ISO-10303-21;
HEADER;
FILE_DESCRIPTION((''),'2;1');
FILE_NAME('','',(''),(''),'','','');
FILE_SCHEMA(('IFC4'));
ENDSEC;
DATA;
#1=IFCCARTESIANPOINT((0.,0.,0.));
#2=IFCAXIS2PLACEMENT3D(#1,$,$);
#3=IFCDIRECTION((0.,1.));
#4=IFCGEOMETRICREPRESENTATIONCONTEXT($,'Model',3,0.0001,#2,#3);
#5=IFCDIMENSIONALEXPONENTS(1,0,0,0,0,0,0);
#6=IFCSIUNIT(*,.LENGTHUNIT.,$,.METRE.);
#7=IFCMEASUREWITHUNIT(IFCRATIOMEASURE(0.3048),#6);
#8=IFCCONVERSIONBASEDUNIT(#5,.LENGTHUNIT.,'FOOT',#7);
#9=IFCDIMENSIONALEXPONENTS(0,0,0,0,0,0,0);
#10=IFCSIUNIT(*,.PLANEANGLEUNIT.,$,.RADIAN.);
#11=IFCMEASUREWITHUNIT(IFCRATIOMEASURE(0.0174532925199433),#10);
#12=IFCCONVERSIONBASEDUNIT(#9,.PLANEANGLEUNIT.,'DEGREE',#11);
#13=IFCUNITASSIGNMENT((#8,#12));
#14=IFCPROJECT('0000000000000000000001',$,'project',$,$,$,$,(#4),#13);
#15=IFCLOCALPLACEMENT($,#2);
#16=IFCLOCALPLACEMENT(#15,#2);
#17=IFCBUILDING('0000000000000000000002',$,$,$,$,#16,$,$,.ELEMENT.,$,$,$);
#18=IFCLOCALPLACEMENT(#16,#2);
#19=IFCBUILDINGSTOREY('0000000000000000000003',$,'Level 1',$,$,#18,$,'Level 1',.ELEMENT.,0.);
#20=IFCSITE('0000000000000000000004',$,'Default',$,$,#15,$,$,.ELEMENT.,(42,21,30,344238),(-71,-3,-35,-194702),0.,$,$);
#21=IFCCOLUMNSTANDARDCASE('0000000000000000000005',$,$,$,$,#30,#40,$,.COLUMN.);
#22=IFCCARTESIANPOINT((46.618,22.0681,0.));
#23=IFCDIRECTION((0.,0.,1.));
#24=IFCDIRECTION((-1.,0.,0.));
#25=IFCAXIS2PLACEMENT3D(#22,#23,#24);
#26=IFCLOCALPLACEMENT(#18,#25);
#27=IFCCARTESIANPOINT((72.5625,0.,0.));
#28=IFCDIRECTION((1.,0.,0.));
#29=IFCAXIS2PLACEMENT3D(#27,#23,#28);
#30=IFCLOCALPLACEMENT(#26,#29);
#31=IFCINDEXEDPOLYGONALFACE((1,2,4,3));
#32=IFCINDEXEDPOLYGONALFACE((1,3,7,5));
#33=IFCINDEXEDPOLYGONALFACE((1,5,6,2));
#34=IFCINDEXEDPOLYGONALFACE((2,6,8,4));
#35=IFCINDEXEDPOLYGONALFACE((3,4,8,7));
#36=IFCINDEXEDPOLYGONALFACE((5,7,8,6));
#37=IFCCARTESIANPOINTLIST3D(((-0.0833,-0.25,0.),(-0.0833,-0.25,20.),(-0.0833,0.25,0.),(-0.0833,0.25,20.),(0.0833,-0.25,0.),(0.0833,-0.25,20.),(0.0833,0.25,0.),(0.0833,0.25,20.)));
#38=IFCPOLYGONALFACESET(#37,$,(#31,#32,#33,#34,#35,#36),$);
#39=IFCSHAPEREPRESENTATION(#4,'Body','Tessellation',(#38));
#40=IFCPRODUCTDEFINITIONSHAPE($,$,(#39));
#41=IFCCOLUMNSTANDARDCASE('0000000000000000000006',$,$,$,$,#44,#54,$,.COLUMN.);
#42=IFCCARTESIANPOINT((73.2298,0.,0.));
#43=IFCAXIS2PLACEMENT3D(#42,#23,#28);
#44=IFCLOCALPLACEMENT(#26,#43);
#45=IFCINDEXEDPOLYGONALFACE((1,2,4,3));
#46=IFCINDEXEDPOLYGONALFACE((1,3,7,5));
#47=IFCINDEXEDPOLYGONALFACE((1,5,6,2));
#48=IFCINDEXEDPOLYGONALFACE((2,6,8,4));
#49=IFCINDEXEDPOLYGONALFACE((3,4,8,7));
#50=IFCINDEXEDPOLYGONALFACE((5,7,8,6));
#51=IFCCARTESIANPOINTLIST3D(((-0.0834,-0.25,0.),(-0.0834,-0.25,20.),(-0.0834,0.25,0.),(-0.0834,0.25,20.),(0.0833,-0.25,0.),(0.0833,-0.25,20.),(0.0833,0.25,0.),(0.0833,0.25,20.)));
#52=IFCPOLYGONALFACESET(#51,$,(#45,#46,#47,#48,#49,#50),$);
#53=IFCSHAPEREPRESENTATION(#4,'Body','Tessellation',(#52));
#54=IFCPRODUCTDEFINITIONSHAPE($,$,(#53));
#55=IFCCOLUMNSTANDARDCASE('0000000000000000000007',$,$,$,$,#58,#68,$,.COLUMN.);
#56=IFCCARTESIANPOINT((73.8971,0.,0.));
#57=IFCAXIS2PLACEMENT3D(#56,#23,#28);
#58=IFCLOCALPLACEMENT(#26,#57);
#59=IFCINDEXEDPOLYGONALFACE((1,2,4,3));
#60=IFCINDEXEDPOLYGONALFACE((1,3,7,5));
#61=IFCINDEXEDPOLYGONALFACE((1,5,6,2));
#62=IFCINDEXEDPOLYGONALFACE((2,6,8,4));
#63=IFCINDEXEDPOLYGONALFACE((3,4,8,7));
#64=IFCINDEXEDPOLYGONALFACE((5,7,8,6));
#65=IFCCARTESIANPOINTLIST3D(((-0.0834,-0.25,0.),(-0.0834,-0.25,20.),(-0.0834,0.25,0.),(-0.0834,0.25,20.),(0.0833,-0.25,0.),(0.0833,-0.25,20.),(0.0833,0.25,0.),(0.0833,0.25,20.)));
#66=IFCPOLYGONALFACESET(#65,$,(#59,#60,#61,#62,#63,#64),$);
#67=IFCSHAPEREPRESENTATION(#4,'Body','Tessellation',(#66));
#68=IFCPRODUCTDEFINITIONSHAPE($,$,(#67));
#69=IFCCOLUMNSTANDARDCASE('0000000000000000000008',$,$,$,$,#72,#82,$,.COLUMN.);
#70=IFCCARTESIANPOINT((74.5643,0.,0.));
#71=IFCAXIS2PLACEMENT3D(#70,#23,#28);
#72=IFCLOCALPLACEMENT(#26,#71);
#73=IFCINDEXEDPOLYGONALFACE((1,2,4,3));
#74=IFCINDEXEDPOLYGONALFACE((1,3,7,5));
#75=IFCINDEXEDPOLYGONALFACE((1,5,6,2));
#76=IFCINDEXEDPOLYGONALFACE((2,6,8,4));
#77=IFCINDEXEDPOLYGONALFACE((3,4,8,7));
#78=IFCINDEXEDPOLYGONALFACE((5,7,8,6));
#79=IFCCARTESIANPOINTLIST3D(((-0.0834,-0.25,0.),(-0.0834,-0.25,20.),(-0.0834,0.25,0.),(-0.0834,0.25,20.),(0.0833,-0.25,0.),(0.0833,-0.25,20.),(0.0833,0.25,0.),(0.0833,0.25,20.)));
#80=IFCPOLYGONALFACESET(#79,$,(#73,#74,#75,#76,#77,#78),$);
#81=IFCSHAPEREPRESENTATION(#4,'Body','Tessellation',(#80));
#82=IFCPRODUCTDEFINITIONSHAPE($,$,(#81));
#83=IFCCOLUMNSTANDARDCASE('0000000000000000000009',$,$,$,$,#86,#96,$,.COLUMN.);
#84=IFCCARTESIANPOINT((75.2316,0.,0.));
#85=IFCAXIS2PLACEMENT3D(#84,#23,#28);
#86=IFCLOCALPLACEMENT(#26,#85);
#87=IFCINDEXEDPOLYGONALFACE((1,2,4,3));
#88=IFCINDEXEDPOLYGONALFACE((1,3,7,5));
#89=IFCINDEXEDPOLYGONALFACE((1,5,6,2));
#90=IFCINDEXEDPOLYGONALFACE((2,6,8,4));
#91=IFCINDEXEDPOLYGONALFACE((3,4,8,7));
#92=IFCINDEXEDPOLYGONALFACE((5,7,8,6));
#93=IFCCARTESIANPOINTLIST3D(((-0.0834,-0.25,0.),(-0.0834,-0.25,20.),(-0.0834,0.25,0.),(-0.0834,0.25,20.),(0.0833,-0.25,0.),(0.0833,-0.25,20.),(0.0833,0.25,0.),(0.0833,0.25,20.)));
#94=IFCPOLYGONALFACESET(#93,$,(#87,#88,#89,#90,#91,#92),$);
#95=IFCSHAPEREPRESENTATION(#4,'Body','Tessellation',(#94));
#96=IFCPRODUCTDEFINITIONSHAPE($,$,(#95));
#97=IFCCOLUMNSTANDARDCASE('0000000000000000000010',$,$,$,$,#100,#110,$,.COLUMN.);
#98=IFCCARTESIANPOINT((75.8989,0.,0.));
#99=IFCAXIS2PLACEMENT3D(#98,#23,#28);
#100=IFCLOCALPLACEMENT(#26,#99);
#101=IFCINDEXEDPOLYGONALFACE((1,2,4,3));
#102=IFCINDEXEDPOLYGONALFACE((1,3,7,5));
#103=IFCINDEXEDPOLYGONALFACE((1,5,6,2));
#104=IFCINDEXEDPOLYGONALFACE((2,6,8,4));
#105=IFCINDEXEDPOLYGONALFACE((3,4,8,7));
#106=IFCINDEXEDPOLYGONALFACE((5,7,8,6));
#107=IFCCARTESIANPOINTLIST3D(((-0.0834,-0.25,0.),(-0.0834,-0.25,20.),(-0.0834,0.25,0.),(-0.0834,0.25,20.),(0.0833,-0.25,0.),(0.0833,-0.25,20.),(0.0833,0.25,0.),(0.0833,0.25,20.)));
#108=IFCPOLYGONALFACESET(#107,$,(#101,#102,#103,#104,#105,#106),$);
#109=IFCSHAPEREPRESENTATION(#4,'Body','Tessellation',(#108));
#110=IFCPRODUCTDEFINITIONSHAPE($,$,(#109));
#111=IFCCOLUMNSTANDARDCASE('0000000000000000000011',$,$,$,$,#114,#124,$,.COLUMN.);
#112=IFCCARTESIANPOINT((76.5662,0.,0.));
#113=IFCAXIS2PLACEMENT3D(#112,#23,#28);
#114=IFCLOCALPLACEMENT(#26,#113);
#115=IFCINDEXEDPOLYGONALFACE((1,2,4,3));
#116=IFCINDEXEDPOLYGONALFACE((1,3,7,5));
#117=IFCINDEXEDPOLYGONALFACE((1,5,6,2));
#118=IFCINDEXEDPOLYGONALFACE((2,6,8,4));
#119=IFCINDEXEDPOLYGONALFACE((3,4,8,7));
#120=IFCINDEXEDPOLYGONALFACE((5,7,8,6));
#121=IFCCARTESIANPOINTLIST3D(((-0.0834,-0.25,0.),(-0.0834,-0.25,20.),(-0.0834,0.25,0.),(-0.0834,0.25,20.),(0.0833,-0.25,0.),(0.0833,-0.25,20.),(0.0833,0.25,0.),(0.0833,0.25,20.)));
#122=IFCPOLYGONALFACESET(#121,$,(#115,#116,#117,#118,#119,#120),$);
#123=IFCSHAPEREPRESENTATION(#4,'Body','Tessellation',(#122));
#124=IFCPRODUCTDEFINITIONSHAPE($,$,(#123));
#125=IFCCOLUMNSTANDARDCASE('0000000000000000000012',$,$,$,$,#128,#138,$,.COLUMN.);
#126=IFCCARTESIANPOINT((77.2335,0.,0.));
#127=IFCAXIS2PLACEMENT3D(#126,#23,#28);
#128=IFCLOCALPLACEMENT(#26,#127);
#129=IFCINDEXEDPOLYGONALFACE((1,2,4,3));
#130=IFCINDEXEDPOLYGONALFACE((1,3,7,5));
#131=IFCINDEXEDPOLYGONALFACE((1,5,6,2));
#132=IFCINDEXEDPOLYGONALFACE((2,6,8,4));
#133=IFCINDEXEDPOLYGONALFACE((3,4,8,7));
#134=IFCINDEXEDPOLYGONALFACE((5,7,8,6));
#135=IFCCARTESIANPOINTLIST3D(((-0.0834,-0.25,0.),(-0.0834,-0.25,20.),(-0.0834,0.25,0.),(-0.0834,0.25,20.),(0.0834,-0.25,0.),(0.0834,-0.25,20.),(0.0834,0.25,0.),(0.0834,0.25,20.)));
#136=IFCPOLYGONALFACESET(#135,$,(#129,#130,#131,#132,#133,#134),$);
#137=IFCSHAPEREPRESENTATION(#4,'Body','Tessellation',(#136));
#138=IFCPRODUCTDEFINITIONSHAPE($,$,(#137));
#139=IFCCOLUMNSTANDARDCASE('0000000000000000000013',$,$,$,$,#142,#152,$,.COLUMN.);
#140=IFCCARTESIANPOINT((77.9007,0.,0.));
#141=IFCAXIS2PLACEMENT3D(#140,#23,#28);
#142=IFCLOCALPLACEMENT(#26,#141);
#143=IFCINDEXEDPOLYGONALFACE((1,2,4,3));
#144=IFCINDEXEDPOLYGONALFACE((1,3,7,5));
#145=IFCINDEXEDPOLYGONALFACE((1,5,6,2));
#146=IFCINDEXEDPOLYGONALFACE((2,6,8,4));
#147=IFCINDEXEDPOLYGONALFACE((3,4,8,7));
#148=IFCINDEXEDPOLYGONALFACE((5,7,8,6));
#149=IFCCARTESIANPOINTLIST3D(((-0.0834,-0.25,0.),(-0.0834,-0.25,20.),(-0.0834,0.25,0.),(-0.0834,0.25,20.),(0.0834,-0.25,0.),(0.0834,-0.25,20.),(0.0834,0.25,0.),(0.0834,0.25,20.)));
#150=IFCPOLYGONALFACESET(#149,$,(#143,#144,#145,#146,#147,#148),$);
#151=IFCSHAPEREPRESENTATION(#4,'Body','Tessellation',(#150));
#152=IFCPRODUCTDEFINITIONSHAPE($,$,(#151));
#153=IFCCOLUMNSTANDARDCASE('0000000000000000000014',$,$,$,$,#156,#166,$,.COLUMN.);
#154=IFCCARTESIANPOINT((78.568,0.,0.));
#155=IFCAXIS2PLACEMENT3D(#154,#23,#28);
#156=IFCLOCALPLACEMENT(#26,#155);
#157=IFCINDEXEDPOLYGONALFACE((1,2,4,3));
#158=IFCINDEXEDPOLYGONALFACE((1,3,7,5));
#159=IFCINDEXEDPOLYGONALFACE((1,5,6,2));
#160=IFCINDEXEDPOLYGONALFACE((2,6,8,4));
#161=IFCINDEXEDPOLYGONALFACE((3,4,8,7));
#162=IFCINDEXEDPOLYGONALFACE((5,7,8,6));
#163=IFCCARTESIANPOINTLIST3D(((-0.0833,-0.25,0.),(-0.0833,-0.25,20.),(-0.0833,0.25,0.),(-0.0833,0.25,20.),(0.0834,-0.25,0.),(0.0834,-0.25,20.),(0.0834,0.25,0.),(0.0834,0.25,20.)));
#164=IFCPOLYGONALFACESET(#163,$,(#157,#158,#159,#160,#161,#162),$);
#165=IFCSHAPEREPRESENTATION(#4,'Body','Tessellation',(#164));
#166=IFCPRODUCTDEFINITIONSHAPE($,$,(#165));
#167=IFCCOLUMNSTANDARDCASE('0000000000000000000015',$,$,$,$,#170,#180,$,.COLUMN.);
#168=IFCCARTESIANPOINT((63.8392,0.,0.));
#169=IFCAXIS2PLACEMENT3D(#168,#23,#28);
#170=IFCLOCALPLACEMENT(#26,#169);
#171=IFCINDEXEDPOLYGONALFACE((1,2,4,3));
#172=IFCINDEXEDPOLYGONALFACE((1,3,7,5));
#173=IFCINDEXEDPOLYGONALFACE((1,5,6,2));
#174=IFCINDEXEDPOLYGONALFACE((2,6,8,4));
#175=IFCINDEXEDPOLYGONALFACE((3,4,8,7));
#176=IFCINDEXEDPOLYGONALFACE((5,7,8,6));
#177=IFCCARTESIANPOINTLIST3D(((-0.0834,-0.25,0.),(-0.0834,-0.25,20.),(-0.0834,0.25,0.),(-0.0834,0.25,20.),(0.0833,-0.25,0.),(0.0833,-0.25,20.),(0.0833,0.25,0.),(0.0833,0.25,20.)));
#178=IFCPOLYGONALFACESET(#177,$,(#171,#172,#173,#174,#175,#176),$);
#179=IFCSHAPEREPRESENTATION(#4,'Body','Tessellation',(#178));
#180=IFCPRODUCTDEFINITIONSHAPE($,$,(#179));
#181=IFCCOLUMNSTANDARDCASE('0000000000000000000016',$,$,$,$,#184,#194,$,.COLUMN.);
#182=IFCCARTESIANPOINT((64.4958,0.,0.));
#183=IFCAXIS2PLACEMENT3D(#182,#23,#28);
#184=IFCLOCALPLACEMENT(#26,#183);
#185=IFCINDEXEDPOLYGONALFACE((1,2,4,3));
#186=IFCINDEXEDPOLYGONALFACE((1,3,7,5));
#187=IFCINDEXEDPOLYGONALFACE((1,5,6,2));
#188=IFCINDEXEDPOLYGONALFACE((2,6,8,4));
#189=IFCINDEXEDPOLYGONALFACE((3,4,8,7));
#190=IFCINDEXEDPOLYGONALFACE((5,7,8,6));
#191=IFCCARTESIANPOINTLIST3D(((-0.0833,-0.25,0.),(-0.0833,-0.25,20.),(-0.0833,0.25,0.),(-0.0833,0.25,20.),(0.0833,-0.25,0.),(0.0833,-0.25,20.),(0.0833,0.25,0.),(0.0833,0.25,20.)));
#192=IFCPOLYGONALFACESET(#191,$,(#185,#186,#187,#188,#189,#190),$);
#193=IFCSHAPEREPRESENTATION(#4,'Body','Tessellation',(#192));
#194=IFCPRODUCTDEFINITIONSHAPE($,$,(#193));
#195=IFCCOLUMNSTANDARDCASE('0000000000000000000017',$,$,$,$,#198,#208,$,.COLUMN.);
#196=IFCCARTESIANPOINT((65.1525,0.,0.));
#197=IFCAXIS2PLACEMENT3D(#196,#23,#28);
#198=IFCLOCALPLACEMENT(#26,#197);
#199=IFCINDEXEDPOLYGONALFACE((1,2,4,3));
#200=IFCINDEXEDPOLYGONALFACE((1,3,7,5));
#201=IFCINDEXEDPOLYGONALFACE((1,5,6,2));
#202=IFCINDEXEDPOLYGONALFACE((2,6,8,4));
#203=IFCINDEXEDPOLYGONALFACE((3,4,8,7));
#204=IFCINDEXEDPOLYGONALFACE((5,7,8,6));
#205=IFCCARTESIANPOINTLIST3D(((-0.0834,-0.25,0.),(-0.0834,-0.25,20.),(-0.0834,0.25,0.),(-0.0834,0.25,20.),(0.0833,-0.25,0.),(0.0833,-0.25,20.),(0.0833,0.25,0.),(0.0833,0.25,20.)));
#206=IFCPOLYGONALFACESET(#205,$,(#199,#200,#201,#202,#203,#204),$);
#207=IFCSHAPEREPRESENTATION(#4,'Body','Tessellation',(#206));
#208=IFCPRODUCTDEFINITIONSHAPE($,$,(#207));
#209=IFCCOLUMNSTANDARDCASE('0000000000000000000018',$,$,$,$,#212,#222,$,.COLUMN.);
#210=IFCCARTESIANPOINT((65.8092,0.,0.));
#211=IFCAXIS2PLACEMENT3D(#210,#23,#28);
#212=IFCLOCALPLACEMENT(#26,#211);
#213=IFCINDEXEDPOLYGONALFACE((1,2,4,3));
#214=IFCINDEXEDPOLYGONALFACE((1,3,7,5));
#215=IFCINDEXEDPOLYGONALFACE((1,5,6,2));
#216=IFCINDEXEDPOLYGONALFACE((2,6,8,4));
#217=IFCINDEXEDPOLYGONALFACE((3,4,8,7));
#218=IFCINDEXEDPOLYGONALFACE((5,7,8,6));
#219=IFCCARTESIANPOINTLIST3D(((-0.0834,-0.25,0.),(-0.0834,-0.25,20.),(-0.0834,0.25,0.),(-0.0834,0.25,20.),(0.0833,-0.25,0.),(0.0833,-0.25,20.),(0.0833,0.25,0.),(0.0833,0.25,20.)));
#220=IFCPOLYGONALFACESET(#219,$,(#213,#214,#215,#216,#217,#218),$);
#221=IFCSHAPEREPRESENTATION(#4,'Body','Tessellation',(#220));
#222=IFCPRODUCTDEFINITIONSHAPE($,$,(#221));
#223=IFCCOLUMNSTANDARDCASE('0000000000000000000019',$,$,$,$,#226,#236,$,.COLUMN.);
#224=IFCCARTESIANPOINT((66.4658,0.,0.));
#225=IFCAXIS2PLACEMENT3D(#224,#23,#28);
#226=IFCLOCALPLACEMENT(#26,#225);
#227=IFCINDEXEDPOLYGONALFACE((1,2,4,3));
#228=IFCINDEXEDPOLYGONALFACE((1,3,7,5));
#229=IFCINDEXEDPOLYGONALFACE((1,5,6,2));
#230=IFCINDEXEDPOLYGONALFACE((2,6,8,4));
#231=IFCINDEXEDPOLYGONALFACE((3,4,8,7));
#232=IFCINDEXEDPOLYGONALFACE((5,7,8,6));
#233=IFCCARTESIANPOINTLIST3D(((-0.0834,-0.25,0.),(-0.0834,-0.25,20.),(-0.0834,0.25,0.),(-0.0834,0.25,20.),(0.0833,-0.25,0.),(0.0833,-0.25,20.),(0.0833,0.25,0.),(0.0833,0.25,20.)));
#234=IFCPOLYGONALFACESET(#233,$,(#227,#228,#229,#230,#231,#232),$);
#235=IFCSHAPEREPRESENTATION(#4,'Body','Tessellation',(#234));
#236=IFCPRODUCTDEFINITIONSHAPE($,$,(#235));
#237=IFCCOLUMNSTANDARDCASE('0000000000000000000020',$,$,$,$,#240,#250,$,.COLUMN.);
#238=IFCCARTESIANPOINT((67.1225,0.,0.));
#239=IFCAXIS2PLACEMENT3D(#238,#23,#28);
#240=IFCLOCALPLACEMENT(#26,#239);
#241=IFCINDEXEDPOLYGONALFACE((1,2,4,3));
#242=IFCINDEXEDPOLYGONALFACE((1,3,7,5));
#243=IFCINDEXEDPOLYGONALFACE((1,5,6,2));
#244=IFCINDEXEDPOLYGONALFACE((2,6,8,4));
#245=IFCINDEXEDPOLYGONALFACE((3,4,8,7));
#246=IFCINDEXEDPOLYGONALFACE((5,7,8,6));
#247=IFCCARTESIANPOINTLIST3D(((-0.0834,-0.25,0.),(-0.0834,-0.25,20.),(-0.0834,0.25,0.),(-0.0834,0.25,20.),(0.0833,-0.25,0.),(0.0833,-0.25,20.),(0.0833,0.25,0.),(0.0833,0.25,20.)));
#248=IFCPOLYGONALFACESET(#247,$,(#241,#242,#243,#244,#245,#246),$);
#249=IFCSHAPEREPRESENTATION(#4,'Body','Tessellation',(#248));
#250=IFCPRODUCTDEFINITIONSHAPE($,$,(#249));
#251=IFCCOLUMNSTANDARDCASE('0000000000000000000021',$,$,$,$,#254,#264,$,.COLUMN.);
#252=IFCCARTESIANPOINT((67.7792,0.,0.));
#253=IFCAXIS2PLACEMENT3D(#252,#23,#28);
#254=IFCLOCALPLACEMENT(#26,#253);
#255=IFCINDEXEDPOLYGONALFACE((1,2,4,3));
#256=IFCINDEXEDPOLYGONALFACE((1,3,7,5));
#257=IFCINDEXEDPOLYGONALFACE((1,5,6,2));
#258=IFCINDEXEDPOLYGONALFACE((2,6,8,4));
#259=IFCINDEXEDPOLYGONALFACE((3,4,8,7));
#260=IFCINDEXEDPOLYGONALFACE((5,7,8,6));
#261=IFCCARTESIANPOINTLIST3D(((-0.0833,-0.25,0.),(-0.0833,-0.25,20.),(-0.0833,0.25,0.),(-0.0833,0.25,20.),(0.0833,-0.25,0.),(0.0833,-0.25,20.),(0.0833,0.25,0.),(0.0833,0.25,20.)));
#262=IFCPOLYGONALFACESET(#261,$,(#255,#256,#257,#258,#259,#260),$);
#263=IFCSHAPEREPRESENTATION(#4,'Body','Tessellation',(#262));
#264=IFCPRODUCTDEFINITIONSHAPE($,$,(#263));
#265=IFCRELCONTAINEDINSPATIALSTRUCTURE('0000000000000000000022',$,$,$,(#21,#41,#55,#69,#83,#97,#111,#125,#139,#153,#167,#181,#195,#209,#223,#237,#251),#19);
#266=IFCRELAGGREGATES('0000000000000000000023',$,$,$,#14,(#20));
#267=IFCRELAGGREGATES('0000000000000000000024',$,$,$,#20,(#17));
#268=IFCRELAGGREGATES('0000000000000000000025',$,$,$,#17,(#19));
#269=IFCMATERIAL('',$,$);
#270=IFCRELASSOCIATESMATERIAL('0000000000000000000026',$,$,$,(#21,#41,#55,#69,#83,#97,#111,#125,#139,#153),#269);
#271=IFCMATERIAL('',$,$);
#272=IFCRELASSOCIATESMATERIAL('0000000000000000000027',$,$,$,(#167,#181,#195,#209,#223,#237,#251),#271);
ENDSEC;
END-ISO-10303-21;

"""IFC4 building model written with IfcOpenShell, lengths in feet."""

from ifc_helpers import new_model, entity, si_unit, converted_unit, direction, frame, origin, place, context, project, spatial, rectangle, extrude, material, element, save


model = new_model("IFC4")

# Units and contexts
model_context = context("Model", 3, precision=0.0001, world=origin(), true_north=direction((0.0, 1.0)))
ifc_project = project(units=[converted_unit("LENGTHUNIT", "FOOT", entity("IfcRatioMeasure", 0.3048), si_unit("LENGTHUNIT", "METRE"), dimensions=[1, 0, 0, 0, 0, 0, 0]), converted_unit("PLANEANGLEUNIT", "DEGREE", entity("IfcRatioMeasure", 0.0174532925199433), si_unit("PLANEANGLEUNIT", "RADIAN"), dimensions=[0, 0, 0, 0, 0, 0, 0])], contexts=[model_context])

# Site, building, storey
site_placement = place(None, origin())
site = spatial("IfcSite", under=ifc_project, at=site_placement, Name="Default", CompositionType="ELEMENT", RefLatitude=(42, 21, 30, 344238), RefLongitude=(-71, -3, -35, -194702), RefElevation=0.0)
building_placement = place(site_placement, origin())
building = spatial("IfcBuilding", under=site, at=building_placement, CompositionType="ELEMENT")
storey_placement = place(building_placement, origin())
storey = spatial("IfcBuildingStorey", under=building, at=storey_placement, Name="Level 1", LongName="Level 1", CompositionType="ELEMENT", Elevation=0.0)

# Columns
ifc_material_1 = material(Name="")
placement = place(storey_placement, frame((46.618, 22.0681, 0.0), z_axis=(0.0, 0.0, 1.0), x_axis=(-1.0, 0.0, 0.0)))
for number, where, z_axis, x_axis in (
    (1, (72.5625, 0.0, 0.0), (0.0, 0.0, 1.0), (1.0, 0.0, 0.0)),
    (2, (73.2298, 0.0, 0.0), (0.0, 0.0, 1.0), (1.0, 0.0, 0.0)),
    (3, (73.8971, 0.0, 0.0), (0.0, 0.0, 1.0), (1.0, 0.0, 0.0)),
    (4, (74.5643, 0.0, 0.0), (0.0, 0.0, 1.0), (1.0, 0.0, 0.0)),
    (5, (75.2316, 0.0, 0.0), (0.0, 0.0, 1.0), (1.0, 0.0, 0.0)),
    (6, (75.8989, 0.0, 0.0), (0.0, 0.0, 1.0), (1.0, 0.0, 0.0)),
    (7, (76.5662, 0.0, 0.0), (0.0, 0.0, 1.0), (1.0, 0.0, 0.0)),
    (8, (77.2335, 0.0, 0.0), (0.0, 0.0, 1.0), (1.0, 0.0, 0.0)),
    (9, (77.9007, 0.0, 0.0), (0.0, 0.0, 1.0), (1.0, 0.0, 0.0)),
    (10, (78.568, 0.0, 0.0), (0.0, 0.0, 1.0), (1.0, 0.0, 0.0)),
):
    element("IfcColumnStandardCase", number, at=place(placement, frame(where, z_axis=z_axis, x_axis=x_axis)), inside=storey, material=ifc_material_1, PredefinedType="COLUMN", context=model_context, shape_type="SweptSolid", body=[
        extrude(rectangle(XDim=0.1667, YDim=0.5), origin(), (0.0, 0.0, 1.0), 20.0),
    ])
ifc_material_2 = material(Name="")
for number, where, z_axis, x_axis in (
    (11, (63.8392, 0.0, 0.0), (0.0, 0.0, 1.0), (1.0, 0.0, 0.0)),
    (12, (64.4958, 0.0, 0.0), (0.0, 0.0, 1.0), (1.0, 0.0, 0.0)),
    (13, (65.1525, 0.0, 0.0), (0.0, 0.0, 1.0), (1.0, 0.0, 0.0)),
    (14, (65.8092, 0.0, 0.0), (0.0, 0.0, 1.0), (1.0, 0.0, 0.0)),
    (15, (66.4658, 0.0, 0.0), (0.0, 0.0, 1.0), (1.0, 0.0, 0.0)),
    (16, (67.1225, 0.0, 0.0), (0.0, 0.0, 1.0), (1.0, 0.0, 0.0)),
    (17, (67.7792, 0.0, 0.0), (0.0, 0.0, 1.0), (1.0, 0.0, 0.0)),
):
    element("IfcColumnStandardCase", number, at=place(placement, frame(where, z_axis=z_axis, x_axis=x_axis)), inside=storey, material=ifc_material_2, PredefinedType="COLUMN", context=model_context, shape_type="SweptSolid", body=[
        extrude(rectangle(XDim=0.1667, YDim=0.5), origin(), (0.0, 0.0, 1.0), 20.0),
    ])

save(model, "model.ifc")
